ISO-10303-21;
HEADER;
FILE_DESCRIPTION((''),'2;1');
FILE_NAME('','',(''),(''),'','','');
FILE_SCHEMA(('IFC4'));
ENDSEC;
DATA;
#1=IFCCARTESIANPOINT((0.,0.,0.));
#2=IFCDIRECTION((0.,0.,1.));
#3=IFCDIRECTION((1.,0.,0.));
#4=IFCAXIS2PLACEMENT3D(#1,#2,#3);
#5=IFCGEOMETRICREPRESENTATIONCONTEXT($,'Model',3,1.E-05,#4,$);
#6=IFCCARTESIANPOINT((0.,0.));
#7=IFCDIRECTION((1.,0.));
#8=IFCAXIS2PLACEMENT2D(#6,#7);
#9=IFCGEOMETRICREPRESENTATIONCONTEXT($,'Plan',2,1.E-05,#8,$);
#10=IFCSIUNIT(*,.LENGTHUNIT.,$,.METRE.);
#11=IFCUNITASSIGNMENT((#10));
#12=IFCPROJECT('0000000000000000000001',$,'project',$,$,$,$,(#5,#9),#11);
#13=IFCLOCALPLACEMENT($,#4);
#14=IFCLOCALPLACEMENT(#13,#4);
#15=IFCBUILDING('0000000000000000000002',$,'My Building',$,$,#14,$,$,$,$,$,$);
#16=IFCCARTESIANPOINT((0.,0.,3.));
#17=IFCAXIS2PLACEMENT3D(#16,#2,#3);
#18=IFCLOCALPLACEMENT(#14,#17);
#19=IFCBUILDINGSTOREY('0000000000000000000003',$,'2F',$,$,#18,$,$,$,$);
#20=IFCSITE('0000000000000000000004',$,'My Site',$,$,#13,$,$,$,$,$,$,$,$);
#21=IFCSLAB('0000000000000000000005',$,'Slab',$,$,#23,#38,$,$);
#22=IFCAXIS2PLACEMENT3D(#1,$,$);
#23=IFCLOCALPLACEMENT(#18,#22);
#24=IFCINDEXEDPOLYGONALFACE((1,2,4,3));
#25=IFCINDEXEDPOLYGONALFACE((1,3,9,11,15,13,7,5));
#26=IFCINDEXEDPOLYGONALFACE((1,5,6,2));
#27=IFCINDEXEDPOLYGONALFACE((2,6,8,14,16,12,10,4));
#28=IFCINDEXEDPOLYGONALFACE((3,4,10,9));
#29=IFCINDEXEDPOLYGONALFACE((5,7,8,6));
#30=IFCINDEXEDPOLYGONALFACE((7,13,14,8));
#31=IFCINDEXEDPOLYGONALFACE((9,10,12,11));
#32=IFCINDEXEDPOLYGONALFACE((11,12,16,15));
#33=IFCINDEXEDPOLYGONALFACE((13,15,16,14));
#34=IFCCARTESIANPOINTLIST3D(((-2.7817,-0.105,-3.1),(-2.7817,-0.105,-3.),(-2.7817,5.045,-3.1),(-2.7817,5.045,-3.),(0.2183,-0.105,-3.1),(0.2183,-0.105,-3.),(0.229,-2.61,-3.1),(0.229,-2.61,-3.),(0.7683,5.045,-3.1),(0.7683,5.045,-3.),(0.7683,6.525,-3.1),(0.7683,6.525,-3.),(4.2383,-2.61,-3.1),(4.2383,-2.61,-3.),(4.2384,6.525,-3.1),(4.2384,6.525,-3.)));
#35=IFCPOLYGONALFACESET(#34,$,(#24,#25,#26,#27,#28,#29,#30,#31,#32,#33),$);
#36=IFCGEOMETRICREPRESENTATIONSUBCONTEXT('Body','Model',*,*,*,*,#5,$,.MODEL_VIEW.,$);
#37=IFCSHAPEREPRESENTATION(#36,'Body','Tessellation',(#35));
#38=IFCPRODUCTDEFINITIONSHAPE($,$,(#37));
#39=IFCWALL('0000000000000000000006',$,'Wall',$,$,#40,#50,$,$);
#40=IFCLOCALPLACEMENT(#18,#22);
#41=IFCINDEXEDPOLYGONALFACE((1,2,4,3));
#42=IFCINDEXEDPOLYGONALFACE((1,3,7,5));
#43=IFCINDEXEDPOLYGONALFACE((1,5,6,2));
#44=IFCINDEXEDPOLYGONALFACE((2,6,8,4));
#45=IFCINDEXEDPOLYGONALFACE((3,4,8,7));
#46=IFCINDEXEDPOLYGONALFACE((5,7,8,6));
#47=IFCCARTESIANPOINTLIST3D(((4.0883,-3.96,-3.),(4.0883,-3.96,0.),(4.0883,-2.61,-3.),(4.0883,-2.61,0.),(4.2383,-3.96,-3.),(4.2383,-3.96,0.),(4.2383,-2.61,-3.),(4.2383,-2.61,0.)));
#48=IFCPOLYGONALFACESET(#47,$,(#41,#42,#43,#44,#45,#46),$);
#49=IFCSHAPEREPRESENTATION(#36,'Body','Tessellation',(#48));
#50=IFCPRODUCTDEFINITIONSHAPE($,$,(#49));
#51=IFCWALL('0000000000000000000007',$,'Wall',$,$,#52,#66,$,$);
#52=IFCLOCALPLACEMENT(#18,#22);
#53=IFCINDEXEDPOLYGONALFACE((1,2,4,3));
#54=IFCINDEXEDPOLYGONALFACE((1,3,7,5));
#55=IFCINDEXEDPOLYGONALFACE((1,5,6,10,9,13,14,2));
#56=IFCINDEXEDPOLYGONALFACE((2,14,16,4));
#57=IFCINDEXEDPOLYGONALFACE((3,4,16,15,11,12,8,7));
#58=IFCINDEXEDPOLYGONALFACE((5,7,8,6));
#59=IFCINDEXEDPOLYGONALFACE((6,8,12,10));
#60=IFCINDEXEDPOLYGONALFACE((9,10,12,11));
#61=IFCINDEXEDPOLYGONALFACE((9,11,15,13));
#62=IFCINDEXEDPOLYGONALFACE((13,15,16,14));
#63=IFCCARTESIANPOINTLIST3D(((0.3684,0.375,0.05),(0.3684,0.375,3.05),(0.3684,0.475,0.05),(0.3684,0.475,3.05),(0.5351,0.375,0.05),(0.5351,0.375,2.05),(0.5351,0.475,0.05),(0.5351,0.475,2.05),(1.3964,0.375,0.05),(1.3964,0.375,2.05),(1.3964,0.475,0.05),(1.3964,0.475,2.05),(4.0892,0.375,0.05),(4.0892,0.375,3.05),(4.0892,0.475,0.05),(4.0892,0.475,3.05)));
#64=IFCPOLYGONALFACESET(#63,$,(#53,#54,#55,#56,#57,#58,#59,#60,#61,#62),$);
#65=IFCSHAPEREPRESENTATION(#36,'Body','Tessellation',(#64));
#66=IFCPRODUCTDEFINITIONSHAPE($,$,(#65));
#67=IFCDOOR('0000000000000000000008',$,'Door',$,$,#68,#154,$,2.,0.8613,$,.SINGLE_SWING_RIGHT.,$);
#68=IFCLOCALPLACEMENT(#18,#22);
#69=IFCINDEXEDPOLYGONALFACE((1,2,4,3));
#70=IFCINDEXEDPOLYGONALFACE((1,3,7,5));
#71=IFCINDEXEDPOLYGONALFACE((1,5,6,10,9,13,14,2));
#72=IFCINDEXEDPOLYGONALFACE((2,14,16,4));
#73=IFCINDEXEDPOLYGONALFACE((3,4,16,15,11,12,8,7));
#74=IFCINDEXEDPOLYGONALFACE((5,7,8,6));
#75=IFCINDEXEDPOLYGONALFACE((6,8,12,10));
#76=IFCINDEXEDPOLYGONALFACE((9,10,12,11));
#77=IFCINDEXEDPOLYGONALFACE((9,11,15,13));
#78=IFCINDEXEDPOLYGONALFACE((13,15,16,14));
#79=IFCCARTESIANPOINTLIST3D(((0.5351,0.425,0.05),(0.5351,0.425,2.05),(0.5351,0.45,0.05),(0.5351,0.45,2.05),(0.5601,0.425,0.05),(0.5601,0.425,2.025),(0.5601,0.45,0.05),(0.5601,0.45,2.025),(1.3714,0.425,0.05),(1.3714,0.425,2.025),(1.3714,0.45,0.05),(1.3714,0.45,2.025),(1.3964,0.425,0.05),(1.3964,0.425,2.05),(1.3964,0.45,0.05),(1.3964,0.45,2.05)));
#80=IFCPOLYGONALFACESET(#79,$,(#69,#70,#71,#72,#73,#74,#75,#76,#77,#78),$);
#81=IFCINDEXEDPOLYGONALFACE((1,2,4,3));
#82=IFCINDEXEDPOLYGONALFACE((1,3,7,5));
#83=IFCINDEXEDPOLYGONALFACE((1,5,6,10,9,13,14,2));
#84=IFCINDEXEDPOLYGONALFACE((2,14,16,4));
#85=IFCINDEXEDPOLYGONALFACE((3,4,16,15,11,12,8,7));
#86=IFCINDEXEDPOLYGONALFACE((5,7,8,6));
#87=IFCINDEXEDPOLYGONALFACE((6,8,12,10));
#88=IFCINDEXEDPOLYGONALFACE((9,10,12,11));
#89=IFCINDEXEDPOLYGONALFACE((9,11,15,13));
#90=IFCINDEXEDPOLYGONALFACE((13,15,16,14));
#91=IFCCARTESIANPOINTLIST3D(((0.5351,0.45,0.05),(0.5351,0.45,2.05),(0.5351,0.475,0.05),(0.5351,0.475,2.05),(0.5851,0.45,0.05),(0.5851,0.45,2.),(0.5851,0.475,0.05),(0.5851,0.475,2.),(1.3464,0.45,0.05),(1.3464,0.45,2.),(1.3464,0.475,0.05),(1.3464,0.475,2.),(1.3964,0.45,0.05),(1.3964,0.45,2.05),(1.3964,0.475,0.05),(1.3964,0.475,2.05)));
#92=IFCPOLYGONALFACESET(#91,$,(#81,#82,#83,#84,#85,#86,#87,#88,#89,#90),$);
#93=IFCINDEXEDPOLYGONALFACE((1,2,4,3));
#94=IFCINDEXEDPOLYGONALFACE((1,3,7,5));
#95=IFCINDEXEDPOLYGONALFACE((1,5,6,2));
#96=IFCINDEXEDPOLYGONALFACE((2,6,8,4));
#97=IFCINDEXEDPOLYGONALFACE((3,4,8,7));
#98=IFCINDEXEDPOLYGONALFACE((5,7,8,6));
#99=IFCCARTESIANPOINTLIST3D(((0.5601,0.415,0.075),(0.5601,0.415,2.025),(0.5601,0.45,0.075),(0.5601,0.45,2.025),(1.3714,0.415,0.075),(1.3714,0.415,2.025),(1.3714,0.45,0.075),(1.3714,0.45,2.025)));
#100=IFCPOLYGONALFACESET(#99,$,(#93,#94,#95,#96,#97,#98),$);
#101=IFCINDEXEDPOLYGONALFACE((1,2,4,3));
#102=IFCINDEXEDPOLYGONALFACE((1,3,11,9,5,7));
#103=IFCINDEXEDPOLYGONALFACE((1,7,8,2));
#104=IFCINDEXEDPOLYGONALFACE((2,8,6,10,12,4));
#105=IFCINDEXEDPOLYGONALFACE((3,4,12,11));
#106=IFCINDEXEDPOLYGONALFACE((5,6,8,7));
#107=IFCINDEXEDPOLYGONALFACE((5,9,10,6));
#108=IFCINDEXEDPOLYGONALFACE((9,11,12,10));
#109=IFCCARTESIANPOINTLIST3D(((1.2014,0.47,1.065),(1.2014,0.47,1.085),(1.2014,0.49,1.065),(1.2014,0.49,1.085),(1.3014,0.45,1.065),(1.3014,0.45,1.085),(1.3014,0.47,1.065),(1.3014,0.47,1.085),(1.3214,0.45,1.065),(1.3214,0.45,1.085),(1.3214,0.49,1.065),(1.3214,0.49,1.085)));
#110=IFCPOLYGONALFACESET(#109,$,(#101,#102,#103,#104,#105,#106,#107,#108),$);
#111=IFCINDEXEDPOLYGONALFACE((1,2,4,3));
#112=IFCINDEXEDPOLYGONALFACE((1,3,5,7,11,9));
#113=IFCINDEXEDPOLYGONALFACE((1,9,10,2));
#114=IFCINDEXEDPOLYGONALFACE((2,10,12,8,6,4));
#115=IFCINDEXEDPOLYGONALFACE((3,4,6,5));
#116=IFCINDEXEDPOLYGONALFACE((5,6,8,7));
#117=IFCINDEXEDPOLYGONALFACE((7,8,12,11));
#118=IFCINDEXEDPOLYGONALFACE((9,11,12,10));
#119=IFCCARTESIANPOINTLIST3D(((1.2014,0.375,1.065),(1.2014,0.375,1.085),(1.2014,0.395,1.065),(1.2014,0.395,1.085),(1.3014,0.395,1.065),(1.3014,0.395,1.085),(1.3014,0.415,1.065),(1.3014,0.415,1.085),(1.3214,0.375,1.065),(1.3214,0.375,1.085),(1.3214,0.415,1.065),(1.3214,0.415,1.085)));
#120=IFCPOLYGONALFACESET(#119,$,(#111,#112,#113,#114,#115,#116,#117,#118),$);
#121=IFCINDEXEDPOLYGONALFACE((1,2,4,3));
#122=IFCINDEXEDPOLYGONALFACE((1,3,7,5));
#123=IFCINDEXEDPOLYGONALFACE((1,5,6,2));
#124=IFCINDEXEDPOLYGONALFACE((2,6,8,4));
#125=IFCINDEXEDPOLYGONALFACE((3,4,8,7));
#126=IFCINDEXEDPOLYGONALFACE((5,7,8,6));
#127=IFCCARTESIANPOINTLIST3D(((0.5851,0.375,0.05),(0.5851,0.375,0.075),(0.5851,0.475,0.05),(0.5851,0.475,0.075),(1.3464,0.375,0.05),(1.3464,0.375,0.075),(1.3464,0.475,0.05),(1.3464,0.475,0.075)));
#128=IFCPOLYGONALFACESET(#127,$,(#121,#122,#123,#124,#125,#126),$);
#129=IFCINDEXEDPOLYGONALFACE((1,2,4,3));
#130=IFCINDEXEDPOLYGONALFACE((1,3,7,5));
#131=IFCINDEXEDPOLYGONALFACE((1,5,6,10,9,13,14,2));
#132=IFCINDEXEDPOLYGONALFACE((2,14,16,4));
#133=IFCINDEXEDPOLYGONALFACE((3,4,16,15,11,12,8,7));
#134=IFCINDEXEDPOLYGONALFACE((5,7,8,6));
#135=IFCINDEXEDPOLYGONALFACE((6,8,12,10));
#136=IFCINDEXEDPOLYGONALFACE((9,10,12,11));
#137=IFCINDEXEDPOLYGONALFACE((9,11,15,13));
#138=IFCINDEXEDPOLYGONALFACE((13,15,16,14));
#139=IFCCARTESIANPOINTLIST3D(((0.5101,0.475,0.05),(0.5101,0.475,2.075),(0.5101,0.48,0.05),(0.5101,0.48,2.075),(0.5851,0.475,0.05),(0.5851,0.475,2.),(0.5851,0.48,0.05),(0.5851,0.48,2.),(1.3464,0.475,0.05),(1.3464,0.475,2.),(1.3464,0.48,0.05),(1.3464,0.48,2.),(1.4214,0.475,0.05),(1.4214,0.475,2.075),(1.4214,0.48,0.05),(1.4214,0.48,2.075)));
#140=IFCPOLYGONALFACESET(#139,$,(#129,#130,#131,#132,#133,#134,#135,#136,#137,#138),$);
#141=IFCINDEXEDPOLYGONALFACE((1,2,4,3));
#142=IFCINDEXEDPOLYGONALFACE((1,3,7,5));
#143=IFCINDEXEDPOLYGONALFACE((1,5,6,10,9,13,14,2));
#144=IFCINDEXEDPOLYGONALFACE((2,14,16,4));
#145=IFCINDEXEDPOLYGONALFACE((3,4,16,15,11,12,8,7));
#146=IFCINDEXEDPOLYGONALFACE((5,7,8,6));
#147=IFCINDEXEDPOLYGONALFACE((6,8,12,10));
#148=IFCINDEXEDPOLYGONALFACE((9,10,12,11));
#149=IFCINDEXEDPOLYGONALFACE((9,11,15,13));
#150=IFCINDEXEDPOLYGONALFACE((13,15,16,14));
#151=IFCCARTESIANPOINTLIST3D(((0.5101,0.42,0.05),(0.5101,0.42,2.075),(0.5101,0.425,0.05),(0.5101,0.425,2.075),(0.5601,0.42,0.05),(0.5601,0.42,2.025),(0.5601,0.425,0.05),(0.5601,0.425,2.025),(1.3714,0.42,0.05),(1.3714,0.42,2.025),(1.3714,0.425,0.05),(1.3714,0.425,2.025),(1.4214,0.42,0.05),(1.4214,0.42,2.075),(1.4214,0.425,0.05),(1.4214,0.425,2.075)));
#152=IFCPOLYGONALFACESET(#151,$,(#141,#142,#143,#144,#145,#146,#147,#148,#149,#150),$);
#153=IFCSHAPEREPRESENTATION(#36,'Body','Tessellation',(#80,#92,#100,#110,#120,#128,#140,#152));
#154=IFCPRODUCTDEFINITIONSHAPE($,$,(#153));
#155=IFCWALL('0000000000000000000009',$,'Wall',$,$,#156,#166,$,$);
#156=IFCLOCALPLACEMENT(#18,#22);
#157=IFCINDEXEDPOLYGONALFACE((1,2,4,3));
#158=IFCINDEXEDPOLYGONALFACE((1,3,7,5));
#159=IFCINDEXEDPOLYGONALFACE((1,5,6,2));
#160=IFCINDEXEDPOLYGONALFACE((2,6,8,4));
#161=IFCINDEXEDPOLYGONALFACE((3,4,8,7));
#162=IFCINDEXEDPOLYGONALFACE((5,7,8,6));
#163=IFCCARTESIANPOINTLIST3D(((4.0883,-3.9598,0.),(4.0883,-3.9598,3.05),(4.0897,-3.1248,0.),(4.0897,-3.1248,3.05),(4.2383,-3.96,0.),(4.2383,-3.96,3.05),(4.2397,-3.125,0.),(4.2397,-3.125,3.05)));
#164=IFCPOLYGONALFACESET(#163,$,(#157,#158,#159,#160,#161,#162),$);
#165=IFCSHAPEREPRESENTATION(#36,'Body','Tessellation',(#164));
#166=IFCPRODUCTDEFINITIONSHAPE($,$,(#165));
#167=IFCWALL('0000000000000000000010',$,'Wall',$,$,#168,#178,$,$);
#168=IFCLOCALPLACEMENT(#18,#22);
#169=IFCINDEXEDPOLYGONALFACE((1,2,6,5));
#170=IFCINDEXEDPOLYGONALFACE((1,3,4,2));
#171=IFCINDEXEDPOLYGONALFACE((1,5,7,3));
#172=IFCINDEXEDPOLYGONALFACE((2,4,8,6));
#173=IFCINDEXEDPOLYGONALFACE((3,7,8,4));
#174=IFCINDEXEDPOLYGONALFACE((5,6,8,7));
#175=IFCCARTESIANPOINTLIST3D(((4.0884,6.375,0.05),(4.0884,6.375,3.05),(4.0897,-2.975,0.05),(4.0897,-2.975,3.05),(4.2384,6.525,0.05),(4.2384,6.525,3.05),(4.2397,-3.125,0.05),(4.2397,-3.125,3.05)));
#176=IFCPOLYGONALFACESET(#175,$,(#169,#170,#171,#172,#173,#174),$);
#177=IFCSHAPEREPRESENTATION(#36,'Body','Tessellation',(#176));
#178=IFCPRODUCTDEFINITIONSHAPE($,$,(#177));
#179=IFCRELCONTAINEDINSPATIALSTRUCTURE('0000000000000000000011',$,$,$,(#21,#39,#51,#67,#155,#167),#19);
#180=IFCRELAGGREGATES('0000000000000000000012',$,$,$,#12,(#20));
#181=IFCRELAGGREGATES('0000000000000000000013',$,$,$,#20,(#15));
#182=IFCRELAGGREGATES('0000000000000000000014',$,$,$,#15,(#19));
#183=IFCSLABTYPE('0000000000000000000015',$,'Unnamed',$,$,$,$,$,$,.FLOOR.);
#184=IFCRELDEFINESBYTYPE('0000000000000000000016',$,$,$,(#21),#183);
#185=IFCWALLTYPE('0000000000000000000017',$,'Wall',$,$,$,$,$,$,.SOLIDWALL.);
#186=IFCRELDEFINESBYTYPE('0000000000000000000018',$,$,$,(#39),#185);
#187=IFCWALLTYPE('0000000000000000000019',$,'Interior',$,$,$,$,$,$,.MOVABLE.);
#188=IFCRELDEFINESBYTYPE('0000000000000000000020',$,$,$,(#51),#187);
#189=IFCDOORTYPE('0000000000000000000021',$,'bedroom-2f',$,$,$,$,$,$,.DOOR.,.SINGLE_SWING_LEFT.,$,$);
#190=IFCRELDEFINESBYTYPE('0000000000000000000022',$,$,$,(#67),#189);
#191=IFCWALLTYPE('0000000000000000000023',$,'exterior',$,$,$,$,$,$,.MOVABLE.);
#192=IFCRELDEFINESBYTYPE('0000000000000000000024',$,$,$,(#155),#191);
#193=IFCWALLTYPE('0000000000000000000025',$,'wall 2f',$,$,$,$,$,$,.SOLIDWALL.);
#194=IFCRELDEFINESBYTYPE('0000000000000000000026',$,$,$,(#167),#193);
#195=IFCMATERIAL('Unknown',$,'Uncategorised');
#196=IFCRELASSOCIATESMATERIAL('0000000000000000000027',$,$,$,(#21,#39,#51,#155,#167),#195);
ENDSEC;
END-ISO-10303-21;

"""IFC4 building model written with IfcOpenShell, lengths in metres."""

from ifc_helpers import new_model, entity, si_unit, frame, origin_with_axes, origin_2d_with_axis, place, context, subcontext, project, spatial, line, indexed_curve, outline, extrude, shape, source, transform, mapped, material, type_object, type_shapes, element, fill, save


model = new_model("IFC4")

# Units and contexts
model_context = context("Model", 3, precision=1e-05, world=origin_with_axes())
plan_context = context("Plan", 2, precision=1e-05, world=origin_2d_with_axis())
body_context_1 = subcontext(model_context, "Body", "Model", "MODEL_VIEW")
body_context_2 = subcontext(plan_context, "Body", "Plan", "PLAN_VIEW")
ifc_project = project(units=[si_unit("LENGTHUNIT", "METRE")], contexts=[model_context, plan_context])

# Site, building, storey
site_placement = place(None, origin_with_axes())
site = spatial("IfcSite", under=ifc_project, at=site_placement, Name="My Site")
building_placement = place(site_placement, origin_with_axes())
building = spatial("IfcBuilding", under=site, at=building_placement, Name="My Building")
storey_placement = place(building_placement, frame((0.0, 0.0, 3.0), z_axis=(0.0, 0.0, 1.0), x_axis=(1.0, 0.0, 0.0)))
storey = spatial("IfcBuildingStorey", under=building, at=storey_placement, Name="2F")

# Slab
ifc_material = material(Name="Unknown", Category="Uncategorised")
slab_type = type_object("IfcSlabType", Name="Unnamed", PredefinedType="FLOOR")
slab_placement = place(storey_placement, frame((4.2383, -2.61, -3.0), z_axis=(0.0, 0.0, 1.0), x_axis=(1.0, 0.0, 0.0)))
element("IfcSlab", 1, at=slab_placement, inside=storey, type_object=slab_type, material=ifc_material, Name="Slab", context=body_context_1, shape_type="SweptSolid", body=[
    extrude(outline(indexed_curve([(0.0, 0.0), (0.0, 9.135), (-3.47, 9.135), (-3.47, 7.655), (-7.02, 7.655), (-7.02, 2.505), (-4.02, 2.505), (-4.0094, 0.0), (0.0, 0.0)])), frame((0.0, 0.0, -0.1), z_axis=(0.0, 0.0, 1.0), x_axis=(1.0, 0.0, 0.0)), (0.0, 0.0, 1.0), 0.1),
])

# Wall
wall_type_1 = type_object("IfcWallType", Name="Wall", PredefinedType="SOLIDWALL")
wall_1_placement = place(storey_placement, frame((4.0883, -2.61, -3.0), z_axis=(0.0, 0.0, 1.0), x_axis=(0.0, -1.0, 0.0)))
element("IfcWall", 2, at=wall_1_placement, inside=storey, type_object=wall_type_1, material=ifc_material, Name="Wall", context=body_context_1, shape_type="SweptSolid", body=[
    extrude(outline(indexed_curve([(0.0, 0.0), (0.0, 0.15), (1.35, 0.15), (1.35, 0.0)], segments=[line(1, 2, 3, 4, 1)])), origin_with_axes(), (0.0, 0.0, 1.0), 3.0),
])

# Wall, opening, door
wall_type_2 = type_object("IfcWallType", Name="Interior", PredefinedType="MOVABLE")
wall_2_placement = place(storey_placement, frame((0.3684, 0.375, 0.05), z_axis=(0.0, 0.0, 1.0), x_axis=(1.0, 0.0, 0.0)))
wall_2 = element("IfcWall", 3, at=wall_2_placement, inside=storey, type_object=wall_type_2, material=ifc_material, Name="Wall", context=body_context_1, shape_type="SweptSolid", body=[
    extrude(outline(indexed_curve([(0.0, 0.0), (0.0, 0.1), (3.7209, 0.1), (3.7209, 0.0)], segments=[line(1, 2, 3, 4, 1)])), origin_with_axes(), (0.0, 0.0, 1.0), 3.0),
])
shared_shape_1 = source(origin_with_axes(), body_context_1, "Body", "SweptSolid", [
    extrude(outline(indexed_curve([(0.0, 0.0), (0.8613, 0.0), (0.8613, 2.0), (0.0, 2.0)], segments=[line(1, 2, 3, 4, 1)])), frame((0.0, -0.6, 0.0), z_axis=(0.0, -1.0, 0.0), x_axis=(1.0, 0.0, 0.0)), (0.0, 0.0, -1.0), 1.2),
])
opening_1_placement = place(wall_2_placement, frame((1.028, 0.1, 0.0), z_axis=(0.0, 0.0, 1.0), x_axis=(-1.0, 0.0, 0.0)))
opening_1 = element("IfcOpeningElement", 4, at=opening_1_placement, cuts=wall_2, PredefinedType="OPENING", context=body_context_1, shape_type="MappedRepresentation", body=[
    mapped(shared_shape_1, transform((0.0, 0.0, 0.0), x_axis=(1.0, 0.0, 0.0), y_axis=(0.0, 1.0, 0.0), z_axis=(0.0, 0.0, 1.0), scale=1.0)),
])
door_type_1 = type_object("IfcDoorType", Name="bedroom-2f", OperationType="SINGLE_SWING_LEFT", PredefinedType="DOOR")
shared_shape_2 = source(origin_with_axes(), body_context_1, "Body", "SweptSolid", [
    extrude(outline(indexed_curve([(0.0, 0.0), (0.0, 2.0), (0.8613, 2.0), (0.8613, 0.0), (0.8363, 0.0), (0.8363, 1.975), (0.025, 1.975), (0.025, 0.0)], segments=[line(1, 2, 3, 4, 5, 6, 7, 8, 1)])), frame((0.0, 0.025, 0.0), z_axis=(0.0, -1.0, 0.0), x_axis=(1.0, 0.0, 0.0)), (0.0, 0.0, -1.0), 0.025),
    extrude(outline(indexed_curve([(0.0, 0.0), (0.0, 2.0), (0.8613, 2.0), (0.8613, 0.0), (0.8113, 0.0), (0.8113, 1.95), (0.05, 1.95), (0.05, 0.0)], segments=[line(1, 2, 3, 4, 5, 6, 7, 8, 1)])), frame((0.0, 0.0, 0.0), z_axis=(0.0, -1.0, 0.0), x_axis=(1.0, 0.0, 0.0)), (0.0, 0.0, -1.0), 0.025),
    extrude(outline(indexed_curve([(0.0, 0.0), (0.8113, 0.0), (0.8113, 0.035), (0.0, 0.035)], segments=[line(1, 2, 3, 4, 1)])), frame((0.025, 0.025, 0.025), z_axis=(0.0, 0.0, 1.0), x_axis=(1.0, 0.0, 0.0)), (0.0, 0.0, 1.0), 1.95),
    extrude(outline(indexed_curve([(0.0, 0.0), (0.0, -0.04), (0.12, -0.04), (0.12, -0.02), (0.02, -0.02), (0.02, 0.0)], segments=[line(1, 2, 3, 4, 5, 6, 1)])), frame((0.075, 0.025, 1.015), z_axis=(0.0, 0.0, 1.0), x_axis=(1.0, 0.0, 0.0)), (0.0, 0.0, 1.0), 0.02),
    extrude(outline(indexed_curve([(0.0, 0.0), (0.0, 0.04), (0.12, 0.04), (0.12, 0.02), (0.02, 0.02), (0.02, 0.0)], segments=[line(1, 2, 3, 4, 5, 6, 1)])), frame((0.075, 0.06, 1.015), z_axis=(0.0, 0.0, 1.0), x_axis=(1.0, 0.0, 0.0)), (0.0, 0.0, 1.0), 0.02),
    extrude(outline(indexed_curve([(0.0, 0.0), (0.7613, 0.0), (0.7613, 0.1), (0.0, 0.1)], segments=[line(1, 2, 3, 4, 1)])), frame((0.05, 0.0, 0.0), z_axis=(0.0, 0.0, 1.0), x_axis=(1.0, 0.0, 0.0)), (0.0, 0.0, 1.0), 0.025),
    extrude(outline(indexed_curve([(0.0, 0.0), (0.0, 2.025), (0.9113, 2.025), (0.9113, 0.0), (0.8363, 0.0), (0.8363, 1.95), (0.075, 1.95), (0.075, 0.0)], segments=[line(1, 2, 3, 4, 5, 6, 7, 8, 1)])), frame((-0.025, -0.005, 0.0), z_axis=(0.0, -1.0, 0.0), x_axis=(1.0, 0.0, 0.0)), (0.0, 0.0, -1.0), 0.005),
    extrude(outline(indexed_curve([(0.0, 0.0), (0.0, 2.025), (0.9113, 2.025), (0.9113, 0.0), (0.8613, 0.0), (0.8613, 1.975), (0.05, 1.975), (0.05, 0.0)], segments=[line(1, 2, 3, 4, 5, 6, 7, 8, 1)])), frame((-0.025, 0.05, 0.0), z_axis=(0.0, -1.0, 0.0), x_axis=(1.0, 0.0, 0.0)), (0.0, 0.0, -1.0), 0.005),
])
shared_shape_3 = source(origin_with_axes(), body_context_2, "Body", "Curve2D", [
    entity("IfcIndexedPolyCurve", entity("IfcCartesianPointList2D", [[0.0, 0.0], [0.0, 0.05], [0.025, 0.05], [0.025, 0.025], [0.05, 0.025], [0.05, 0.0]]), [entity("IfcLineIndex", [1, 2, 3, 4, 5, 6, 1])]),
    entity("IfcIndexedPolyCurve", entity("IfcCartesianPointList2D", [[0.8613, 0.0], [0.8613, 0.05], [0.8363, 0.05], [0.8363, 0.025], [0.8113, 0.025], [0.8113, 0.0]]), [entity("IfcLineIndex", [1, 2, 3, 4, 5, 6, 1])]),
    entity("IfcTrimmedCurve", entity("IfcEllipse", entity("IfcAxis2Placement2D", entity("IfcCartesianPoint", [0.8013, 0.05]), entity("IfcDirection", [1.0, 0.0])), 0.7763, 0.8113), [entity("IfcCartesianPoint", [0.8013, 0.8613])], [entity("IfcCartesianPoint", [0.025, 0.05])], True, "CARTESIAN"),
    entity("IfcIndexedPolyCurve", entity("IfcCartesianPointList2D", [[0.8363, 0.05], [0.8013, 0.05], [0.8013, 0.8613], [0.8363, 0.8613]]), [entity("IfcLineIndex", [1, 2, 3, 4, 1])]),
])
type_shapes(door_type_1, [shared_shape_2, shared_shape_3])
door_1_placement = place(opening_1_placement, origin_with_axes())
door_1 = element("IfcDoor", 5, at=door_1_placement, inside=storey, type_object=door_type_1, Name="Door", OperationType="SINGLE_SWING_RIGHT", OverallHeight=2.0, OverallWidth=0.8613, shapes=[
    shape(body_context_1, "Body", "MappedRepresentation", [mapped(shared_shape_2, transform((0.0, 0.0, 0.0), x_axis=(1.0, 0.0, 0.0), y_axis=(0.0, 1.0, 0.0), z_axis=(0.0, 0.0, 1.0), scale=1.0))]),
    shape(body_context_2, "Body", "MappedRepresentation", [mapped(shared_shape_3, transform((0.0, 0.0, 0.0), x_axis=(1.0, 0.0, 0.0), y_axis=(0.0, 1.0, 0.0), z_axis=(0.0, 0.0, 1.0), scale=1.0))]),
])
fill(opening_1, door_1)

# Walls
wall_type_3 = type_object("IfcWallType", Name="exterior", PredefinedType="MOVABLE")
wall_3_placement = place(storey_placement, frame((4.2383, -3.96, 0.0), z_axis=(0.0, 0.0, 1.0), x_axis=(0.00165, 0.999999, 0.0)))
element("IfcWall", 6, at=wall_3_placement, inside=storey, type_object=wall_type_3, material=ifc_material, Name="Wall", context=body_context_1, shape_type="SweptSolid", body=[
    extrude(outline(indexed_curve([(0.0, 0.0), (0.0, 0.15), (0.835, 0.15), (0.835, 0.0)], segments=[line(1, 2, 3, 4, 1)])), origin_with_axes(), (0.0, 0.0, 1.0), 3.05),
])
wall_type_4 = type_object("IfcWallType", Name="wall 2f", PredefinedType="SOLIDWALL")
wall_4_placement = place(storey_placement, frame((4.2397, -3.125, 0.05), z_axis=(0.0, 0.0, 1.0), x_axis=(-0.000142, 1.0, 0.0)))
element("IfcWall", 7, at=wall_4_placement, inside=storey, type_object=wall_type_4, material=ifc_material, Name="Wall", context=body_context_1, shape_type="SweptSolid", body=[
    extrude(outline(indexed_curve([(0.0, 0.0), (0.15, 0.15), (9.5, 0.15), (9.65, 0.0)], segments=[line(1, 2, 3, 4, 1)])), origin_with_axes(), (0.0, 0.0, 1.0), 3.0),
])

save(model, "model.ifc")
